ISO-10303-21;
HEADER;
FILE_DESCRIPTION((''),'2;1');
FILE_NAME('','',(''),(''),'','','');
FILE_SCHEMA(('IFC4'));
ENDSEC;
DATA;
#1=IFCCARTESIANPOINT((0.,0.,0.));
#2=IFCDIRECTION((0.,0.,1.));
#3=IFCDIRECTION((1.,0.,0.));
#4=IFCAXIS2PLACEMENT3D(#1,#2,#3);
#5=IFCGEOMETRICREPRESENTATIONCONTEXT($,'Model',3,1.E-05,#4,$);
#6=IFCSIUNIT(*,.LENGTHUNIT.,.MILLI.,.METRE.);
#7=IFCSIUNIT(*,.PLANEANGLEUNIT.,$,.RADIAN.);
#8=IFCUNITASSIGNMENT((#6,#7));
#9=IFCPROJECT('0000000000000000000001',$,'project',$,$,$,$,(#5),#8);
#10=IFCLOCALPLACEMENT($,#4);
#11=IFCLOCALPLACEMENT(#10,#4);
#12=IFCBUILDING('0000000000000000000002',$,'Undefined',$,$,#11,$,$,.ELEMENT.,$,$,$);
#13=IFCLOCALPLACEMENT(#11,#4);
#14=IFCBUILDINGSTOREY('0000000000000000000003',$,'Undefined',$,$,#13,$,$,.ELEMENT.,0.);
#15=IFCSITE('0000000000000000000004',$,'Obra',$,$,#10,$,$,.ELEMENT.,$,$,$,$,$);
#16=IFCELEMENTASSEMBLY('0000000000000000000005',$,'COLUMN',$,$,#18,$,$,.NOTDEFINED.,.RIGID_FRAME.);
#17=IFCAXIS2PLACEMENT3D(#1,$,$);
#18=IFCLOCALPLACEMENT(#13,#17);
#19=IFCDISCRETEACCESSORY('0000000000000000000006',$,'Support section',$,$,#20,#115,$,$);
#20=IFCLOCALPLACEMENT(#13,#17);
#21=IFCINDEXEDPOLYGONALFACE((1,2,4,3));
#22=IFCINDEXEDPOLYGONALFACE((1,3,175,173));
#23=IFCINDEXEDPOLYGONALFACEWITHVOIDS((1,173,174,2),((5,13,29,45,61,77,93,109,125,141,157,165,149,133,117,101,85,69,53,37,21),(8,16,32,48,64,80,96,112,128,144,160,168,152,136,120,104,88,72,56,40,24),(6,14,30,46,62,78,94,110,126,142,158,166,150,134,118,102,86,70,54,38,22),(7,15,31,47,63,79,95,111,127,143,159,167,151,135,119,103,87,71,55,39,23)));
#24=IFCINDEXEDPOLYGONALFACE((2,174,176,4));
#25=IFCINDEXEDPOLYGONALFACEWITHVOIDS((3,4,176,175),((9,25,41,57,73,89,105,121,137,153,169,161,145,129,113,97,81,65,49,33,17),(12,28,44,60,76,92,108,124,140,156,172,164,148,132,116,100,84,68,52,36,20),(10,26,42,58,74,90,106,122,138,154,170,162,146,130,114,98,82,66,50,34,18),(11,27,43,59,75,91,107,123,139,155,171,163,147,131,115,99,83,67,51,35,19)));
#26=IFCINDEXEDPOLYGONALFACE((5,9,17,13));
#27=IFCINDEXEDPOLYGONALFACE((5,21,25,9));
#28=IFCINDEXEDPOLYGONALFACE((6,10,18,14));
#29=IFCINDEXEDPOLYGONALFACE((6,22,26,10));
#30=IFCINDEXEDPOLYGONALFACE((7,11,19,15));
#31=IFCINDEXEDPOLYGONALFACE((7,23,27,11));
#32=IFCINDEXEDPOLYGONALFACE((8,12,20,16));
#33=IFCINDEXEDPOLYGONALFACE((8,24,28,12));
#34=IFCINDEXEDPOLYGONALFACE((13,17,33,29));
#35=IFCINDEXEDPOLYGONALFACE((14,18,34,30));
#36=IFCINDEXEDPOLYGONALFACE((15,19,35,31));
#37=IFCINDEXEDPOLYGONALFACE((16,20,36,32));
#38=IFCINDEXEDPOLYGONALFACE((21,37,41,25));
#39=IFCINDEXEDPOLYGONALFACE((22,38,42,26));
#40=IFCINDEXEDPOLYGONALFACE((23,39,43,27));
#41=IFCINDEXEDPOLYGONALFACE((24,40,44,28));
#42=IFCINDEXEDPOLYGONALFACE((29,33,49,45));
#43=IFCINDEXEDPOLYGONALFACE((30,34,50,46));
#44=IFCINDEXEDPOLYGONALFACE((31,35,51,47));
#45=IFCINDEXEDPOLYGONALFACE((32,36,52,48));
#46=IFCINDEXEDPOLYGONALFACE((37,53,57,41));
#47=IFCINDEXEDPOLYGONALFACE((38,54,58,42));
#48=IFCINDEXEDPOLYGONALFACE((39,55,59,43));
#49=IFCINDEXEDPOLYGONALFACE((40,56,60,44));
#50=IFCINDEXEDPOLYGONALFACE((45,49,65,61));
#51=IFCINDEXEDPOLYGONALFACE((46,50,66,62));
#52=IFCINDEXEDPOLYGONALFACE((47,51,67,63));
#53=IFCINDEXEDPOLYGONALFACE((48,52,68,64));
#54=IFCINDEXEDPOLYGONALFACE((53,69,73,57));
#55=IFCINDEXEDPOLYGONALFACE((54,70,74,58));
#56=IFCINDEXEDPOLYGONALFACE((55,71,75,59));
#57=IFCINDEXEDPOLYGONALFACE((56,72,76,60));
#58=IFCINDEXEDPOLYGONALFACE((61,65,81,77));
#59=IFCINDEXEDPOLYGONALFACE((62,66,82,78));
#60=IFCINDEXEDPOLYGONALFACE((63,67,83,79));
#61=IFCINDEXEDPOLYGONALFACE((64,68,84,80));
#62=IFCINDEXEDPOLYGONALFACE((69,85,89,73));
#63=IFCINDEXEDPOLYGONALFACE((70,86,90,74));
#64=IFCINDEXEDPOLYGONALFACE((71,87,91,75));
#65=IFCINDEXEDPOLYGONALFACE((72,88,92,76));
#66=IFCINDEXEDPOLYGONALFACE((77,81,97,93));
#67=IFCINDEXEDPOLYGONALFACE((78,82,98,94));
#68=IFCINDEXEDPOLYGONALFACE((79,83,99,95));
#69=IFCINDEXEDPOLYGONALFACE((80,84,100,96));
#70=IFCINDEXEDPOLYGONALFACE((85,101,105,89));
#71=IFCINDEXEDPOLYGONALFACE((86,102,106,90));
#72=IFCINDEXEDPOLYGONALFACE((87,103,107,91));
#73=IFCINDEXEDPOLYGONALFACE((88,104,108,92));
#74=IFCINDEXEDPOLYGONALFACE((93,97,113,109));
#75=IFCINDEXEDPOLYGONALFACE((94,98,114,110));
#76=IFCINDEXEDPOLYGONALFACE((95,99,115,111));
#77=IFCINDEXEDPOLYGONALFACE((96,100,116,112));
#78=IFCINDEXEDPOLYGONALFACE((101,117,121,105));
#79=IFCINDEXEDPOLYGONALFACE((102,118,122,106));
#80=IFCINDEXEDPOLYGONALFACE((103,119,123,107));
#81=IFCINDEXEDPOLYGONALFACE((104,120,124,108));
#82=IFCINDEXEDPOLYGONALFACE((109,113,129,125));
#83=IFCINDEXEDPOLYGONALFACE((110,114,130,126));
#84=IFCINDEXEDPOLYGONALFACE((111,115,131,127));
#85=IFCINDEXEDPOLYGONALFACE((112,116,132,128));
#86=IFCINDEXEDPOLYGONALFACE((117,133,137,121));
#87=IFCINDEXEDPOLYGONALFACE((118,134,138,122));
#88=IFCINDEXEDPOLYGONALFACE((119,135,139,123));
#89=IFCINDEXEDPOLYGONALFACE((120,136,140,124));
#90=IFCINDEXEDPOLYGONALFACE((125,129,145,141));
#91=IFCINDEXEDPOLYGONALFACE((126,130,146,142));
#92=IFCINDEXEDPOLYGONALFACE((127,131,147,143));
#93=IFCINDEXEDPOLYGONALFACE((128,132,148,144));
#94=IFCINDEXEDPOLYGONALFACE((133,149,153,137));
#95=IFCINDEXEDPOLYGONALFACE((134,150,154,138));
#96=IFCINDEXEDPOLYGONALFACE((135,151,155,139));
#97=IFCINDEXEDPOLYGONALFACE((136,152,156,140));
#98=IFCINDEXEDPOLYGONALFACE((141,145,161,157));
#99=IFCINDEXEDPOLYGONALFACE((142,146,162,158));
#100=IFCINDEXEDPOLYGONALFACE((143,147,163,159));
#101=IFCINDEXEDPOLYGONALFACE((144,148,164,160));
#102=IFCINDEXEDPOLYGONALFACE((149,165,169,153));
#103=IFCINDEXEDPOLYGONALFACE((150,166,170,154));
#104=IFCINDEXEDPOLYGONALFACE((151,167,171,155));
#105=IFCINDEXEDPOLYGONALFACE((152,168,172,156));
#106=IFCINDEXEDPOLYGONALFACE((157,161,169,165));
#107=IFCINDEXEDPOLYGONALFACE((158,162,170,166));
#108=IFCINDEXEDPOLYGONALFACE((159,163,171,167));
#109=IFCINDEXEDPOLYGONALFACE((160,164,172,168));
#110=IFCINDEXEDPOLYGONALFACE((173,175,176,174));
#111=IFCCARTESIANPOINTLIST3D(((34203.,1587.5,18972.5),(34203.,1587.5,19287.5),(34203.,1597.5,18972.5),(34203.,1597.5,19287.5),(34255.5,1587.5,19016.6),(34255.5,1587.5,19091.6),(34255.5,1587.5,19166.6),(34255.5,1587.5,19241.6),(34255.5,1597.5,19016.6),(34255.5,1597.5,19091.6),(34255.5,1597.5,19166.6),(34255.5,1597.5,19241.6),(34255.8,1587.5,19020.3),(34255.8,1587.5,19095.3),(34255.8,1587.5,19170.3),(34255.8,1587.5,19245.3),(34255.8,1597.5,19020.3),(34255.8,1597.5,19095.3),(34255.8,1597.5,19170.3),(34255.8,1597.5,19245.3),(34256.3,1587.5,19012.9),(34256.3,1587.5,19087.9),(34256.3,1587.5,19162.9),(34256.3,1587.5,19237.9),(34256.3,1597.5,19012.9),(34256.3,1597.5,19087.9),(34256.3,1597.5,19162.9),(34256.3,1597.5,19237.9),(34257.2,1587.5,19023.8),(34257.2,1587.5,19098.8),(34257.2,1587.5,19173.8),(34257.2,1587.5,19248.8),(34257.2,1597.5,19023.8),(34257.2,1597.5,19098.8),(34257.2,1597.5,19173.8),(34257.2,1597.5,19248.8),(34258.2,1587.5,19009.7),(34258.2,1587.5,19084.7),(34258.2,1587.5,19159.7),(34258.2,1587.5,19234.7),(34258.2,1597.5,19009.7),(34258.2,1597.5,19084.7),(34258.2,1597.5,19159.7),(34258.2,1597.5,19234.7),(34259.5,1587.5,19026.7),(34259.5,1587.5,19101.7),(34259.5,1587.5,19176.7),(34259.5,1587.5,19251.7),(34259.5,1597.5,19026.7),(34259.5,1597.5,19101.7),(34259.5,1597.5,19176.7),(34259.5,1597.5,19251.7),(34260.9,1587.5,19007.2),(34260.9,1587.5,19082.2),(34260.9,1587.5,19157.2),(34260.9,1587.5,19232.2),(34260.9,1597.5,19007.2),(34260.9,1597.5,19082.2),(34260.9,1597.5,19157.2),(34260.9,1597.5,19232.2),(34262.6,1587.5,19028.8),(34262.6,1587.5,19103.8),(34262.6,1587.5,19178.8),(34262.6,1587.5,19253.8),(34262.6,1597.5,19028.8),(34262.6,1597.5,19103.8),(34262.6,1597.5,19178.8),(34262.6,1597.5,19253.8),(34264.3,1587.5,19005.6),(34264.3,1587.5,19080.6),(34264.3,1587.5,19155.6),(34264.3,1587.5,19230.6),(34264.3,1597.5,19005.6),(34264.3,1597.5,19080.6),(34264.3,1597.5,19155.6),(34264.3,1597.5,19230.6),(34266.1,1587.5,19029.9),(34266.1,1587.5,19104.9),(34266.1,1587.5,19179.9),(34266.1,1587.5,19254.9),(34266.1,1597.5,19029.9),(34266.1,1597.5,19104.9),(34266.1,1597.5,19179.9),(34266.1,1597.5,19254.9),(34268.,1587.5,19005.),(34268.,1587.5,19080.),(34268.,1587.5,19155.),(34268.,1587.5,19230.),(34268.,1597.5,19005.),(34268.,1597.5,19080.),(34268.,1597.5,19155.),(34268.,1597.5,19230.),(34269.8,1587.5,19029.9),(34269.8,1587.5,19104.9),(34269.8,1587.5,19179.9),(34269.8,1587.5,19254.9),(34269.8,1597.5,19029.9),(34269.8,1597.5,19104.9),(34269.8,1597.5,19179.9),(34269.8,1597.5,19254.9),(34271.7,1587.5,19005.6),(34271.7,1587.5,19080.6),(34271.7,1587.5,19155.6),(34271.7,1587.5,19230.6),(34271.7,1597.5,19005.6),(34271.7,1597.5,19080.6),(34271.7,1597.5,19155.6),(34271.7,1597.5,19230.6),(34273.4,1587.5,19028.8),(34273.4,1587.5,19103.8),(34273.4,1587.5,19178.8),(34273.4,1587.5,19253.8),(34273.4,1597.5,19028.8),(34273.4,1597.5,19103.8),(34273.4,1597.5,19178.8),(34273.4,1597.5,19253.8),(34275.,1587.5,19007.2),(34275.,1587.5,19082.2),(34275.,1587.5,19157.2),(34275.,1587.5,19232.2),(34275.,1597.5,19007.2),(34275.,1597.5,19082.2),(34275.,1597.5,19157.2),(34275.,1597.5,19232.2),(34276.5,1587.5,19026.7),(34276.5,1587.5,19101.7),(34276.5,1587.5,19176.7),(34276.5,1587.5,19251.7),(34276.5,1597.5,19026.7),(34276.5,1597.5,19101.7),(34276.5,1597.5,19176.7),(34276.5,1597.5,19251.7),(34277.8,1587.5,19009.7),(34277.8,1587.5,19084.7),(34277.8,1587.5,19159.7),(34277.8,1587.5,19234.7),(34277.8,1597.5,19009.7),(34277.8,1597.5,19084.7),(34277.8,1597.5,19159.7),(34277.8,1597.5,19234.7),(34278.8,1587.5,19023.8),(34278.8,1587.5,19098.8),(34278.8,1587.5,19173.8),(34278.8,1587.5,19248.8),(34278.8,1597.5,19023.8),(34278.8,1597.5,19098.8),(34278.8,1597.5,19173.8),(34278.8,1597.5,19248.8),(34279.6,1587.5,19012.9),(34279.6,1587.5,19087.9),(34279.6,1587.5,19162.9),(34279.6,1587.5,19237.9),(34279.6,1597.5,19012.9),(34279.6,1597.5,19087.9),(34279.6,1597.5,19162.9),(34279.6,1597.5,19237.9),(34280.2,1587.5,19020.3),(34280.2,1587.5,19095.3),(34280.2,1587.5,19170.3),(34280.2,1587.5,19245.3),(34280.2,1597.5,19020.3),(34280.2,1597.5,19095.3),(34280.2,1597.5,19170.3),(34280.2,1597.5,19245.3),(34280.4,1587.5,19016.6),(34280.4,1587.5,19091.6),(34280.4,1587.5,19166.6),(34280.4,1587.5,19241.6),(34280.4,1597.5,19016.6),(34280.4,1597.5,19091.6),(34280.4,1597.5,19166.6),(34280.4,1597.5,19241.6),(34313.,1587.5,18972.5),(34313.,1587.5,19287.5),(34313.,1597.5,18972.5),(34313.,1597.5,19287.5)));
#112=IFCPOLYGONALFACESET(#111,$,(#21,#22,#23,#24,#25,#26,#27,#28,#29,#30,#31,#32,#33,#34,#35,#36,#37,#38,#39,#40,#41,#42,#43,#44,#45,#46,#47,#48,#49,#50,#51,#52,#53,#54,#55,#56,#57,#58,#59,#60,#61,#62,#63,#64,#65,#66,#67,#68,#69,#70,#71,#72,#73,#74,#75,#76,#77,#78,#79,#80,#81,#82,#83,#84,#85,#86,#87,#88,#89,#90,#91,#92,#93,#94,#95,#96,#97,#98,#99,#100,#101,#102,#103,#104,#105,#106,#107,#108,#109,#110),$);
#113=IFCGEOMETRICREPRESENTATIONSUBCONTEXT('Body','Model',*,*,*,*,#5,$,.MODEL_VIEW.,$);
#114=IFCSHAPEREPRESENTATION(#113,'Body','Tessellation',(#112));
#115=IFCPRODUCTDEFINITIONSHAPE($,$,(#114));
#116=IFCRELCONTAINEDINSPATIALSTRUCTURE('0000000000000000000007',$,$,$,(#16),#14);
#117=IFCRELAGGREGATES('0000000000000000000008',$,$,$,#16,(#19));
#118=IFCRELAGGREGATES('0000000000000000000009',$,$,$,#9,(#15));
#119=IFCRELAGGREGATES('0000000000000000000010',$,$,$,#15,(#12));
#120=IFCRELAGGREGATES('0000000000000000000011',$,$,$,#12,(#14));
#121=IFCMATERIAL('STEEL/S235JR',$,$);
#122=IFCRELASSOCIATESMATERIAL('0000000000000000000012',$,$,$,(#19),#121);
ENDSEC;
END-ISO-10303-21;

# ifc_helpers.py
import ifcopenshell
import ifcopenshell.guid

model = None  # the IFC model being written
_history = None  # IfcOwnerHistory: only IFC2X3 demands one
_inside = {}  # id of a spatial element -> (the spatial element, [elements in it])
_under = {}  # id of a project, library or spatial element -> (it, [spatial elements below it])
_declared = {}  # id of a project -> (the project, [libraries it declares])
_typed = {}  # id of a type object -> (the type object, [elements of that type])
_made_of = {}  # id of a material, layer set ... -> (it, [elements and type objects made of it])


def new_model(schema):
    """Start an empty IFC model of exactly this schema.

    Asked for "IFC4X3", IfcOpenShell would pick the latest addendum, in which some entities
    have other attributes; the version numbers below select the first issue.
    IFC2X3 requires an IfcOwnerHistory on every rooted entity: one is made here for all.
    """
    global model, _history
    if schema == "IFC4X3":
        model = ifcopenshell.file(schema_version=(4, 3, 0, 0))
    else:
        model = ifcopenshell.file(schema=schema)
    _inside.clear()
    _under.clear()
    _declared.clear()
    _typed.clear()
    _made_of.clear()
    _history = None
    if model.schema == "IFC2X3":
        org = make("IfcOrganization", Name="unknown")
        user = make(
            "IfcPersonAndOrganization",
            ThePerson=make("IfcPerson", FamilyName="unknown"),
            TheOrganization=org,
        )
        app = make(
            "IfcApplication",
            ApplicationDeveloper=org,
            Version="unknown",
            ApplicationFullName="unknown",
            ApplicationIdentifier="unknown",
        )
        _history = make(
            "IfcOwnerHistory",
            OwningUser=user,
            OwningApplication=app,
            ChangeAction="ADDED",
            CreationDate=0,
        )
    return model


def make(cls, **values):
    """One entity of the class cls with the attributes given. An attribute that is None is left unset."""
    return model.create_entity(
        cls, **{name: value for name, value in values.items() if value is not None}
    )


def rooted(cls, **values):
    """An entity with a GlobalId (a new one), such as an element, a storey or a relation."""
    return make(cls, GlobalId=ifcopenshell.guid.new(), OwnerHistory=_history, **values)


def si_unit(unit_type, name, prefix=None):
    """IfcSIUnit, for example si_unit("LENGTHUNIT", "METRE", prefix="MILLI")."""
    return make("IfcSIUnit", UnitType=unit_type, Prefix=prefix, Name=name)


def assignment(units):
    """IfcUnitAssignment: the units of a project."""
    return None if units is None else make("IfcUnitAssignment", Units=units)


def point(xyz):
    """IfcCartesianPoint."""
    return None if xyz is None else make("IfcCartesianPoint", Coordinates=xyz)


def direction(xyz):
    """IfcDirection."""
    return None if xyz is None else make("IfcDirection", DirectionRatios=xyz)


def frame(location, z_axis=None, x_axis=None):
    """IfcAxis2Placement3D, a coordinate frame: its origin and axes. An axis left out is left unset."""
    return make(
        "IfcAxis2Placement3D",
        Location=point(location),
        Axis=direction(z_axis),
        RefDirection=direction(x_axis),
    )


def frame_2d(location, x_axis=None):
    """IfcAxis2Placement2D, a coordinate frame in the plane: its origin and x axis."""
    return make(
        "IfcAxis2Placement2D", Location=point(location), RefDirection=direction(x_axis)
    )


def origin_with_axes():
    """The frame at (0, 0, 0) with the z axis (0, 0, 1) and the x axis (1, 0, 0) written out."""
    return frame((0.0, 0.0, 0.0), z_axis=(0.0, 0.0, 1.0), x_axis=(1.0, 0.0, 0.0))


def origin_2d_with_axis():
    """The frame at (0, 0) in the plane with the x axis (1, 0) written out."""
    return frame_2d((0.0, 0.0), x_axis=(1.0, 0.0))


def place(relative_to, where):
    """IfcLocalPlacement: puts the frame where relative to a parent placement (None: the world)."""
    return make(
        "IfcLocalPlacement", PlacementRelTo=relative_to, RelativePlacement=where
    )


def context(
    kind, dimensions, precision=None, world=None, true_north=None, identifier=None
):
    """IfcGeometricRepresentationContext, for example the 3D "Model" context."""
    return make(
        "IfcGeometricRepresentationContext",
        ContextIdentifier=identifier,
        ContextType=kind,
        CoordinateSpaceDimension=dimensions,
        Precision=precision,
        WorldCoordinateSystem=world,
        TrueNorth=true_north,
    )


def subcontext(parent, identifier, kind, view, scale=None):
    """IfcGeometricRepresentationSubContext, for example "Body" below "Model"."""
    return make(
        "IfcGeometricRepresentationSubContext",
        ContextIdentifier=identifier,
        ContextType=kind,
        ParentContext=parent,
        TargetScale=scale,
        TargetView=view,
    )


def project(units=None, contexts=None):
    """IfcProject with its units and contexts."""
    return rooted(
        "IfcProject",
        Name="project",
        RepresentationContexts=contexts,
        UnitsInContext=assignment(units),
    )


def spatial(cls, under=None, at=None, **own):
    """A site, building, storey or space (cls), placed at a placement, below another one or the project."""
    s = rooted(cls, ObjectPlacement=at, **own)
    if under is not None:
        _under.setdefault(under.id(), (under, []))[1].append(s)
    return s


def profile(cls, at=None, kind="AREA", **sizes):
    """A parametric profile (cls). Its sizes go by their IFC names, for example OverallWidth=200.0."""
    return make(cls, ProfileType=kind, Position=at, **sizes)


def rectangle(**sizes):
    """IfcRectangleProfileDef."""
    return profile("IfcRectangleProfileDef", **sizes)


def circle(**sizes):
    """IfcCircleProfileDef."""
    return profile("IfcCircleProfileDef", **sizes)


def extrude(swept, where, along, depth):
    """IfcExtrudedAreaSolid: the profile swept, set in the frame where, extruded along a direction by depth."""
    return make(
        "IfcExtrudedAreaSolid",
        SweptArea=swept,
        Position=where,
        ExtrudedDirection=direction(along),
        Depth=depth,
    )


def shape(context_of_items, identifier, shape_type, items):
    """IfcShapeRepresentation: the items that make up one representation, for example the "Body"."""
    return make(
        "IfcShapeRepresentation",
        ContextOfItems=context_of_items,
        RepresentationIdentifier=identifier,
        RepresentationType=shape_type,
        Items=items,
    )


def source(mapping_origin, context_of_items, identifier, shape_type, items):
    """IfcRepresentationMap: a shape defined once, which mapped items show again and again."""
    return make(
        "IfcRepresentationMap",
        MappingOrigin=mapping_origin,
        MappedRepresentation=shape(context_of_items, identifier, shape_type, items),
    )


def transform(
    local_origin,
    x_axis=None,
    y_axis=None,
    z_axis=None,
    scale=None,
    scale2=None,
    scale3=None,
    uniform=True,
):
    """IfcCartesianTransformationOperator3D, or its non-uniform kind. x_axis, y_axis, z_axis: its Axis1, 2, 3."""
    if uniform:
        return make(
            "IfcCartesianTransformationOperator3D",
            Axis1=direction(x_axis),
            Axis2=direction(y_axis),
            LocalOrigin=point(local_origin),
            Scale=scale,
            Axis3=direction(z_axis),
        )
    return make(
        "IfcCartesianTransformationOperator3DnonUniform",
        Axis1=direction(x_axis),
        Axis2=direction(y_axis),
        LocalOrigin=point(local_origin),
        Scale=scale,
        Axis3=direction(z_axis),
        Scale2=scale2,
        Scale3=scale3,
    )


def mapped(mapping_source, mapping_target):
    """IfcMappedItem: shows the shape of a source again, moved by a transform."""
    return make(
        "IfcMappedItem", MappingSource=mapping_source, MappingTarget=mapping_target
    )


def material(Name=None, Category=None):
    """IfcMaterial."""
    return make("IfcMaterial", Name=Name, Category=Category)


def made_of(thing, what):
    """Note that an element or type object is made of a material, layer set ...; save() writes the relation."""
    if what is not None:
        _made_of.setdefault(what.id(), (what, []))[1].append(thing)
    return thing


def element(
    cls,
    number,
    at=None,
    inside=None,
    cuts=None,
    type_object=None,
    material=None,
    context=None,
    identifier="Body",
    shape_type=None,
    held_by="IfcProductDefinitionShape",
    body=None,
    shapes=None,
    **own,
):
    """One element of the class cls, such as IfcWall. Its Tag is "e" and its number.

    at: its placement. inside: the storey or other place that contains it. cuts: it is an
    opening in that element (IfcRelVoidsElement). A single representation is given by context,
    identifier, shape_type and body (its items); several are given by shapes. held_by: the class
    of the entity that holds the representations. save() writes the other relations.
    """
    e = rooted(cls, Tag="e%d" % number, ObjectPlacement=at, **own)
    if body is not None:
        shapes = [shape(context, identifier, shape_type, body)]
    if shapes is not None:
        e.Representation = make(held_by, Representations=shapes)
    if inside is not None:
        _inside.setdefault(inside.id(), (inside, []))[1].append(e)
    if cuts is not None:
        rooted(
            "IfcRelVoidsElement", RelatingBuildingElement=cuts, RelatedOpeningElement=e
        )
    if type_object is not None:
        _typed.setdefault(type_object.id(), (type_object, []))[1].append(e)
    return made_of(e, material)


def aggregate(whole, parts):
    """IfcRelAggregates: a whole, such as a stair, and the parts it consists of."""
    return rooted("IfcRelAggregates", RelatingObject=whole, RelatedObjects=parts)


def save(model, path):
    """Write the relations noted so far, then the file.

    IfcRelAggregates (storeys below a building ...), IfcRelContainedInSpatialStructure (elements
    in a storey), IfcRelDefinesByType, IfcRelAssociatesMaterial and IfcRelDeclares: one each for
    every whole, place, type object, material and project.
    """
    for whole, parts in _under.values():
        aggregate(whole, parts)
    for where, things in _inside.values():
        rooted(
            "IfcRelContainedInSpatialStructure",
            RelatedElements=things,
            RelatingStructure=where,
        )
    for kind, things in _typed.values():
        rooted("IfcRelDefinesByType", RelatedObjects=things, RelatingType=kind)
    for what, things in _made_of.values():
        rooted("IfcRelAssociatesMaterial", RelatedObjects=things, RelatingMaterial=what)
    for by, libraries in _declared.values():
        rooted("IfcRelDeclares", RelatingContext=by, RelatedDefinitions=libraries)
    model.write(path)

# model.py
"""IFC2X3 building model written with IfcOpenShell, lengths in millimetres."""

from ifc_helpers import new_model, si_unit, frame, origin_with_axes, origin_2d_with_axis, place, context, subcontext, project, spatial, rectangle, circle, extrude, source, transform, mapped, material, element, aggregate, save


model = new_model("IFC2X3")

# Units and contexts
model_context = context("Model", 3, precision=1e-05, world=origin_with_axes())
body_context = subcontext(model_context, "Body", "Model", "MODEL_VIEW")
ifc_project = project(units=[si_unit("LENGTHUNIT", "METRE", prefix="MILLI"), si_unit("PLANEANGLEUNIT", "RADIAN")], contexts=[model_context])

# Site, building, storey
site_placement = place(None, origin_with_axes())
site = spatial("IfcSite", under=ifc_project, at=site_placement, Name="Obra", CompositionType="ELEMENT")
building_placement = place(site_placement, origin_with_axes())
building = spatial("IfcBuilding", under=site, at=building_placement, Name="Undefined", CompositionType="ELEMENT")
storey_placement = place(building_placement, origin_with_axes())
storey = spatial("IfcBuildingStorey", under=building, at=storey_placement, Name="Undefined", CompositionType="ELEMENT", Elevation=0.0)

# Element assembly
assembly_1_placement = place(storey_placement, origin_with_axes())
assembly_1 = element("IfcElementAssembly", 1, at=assembly_1_placement, inside=storey, Name="COLUMN", AssemblyPlace="NOTDEFINED", PredefinedType="RIGID_FRAME")
ifc_material_1 = material(Name="STEEL/S235JR")

# Discrete accessory, opening
discrete_accessory_1_placement = place(assembly_1_placement, frame((34258.0, 1592.5, 18972.5), z_axis=(0.0, 0.0, 1.0), x_axis=(-1.0, 0.0, 0.0)))
discrete_accessory_1 = element("IfcDiscreteAccessory", 2, at=discrete_accessory_1_placement, material=ifc_material_1, Name="Support section", context=body_context, shape_type="SweptSolid", body=[
    extrude(rectangle(XDim=10.0, YDim=110.0, at=origin_2d_with_axis()), frame((0.0, 0.0, 315.0), z_axis=(0.0, 0.0, -1.0), x_axis=(0.0, 1.0, 0.0)), (0.0, 0.0, 1.0), 315.0),
])
shared_shape_1 = source(origin_with_axes(), body_context, "Body", "SweptSolid", [
    extrude(circle(Radius=12.5, at=origin_2d_with_axis()), frame((0.0, -15.8, 0.0), z_axis=(0.0, 1.0, 0.0), x_axis=(1.0, 0.0, 0.0)), (0.0, 0.0, 1.0), 10.2),
])
opening_1_placement = place(assembly_1_placement, frame((34223.0, 1603.3, 19350.0), z_axis=(1.0, 0.0, 0.0), x_axis=(0.0, 0.0, -1.0)))
element("IfcOpeningElement", 3, at=opening_1_placement, cuts=discrete_accessory_1, ObjectType="Opening", context=body_context, shape_type="MappedRepresentation", body=[
    mapped(shared_shape_1, transform((107.5, 0.0, 45.0))),
    mapped(shared_shape_1, transform((182.5, 0.0, 45.0))),
    mapped(shared_shape_1, transform((257.5, 0.0, 45.0))),
    mapped(shared_shape_1, transform((332.5, 0.0, 45.0))),
])

aggregate(assembly_1, [discrete_accessory_1])

save(model, "model.ifc")
